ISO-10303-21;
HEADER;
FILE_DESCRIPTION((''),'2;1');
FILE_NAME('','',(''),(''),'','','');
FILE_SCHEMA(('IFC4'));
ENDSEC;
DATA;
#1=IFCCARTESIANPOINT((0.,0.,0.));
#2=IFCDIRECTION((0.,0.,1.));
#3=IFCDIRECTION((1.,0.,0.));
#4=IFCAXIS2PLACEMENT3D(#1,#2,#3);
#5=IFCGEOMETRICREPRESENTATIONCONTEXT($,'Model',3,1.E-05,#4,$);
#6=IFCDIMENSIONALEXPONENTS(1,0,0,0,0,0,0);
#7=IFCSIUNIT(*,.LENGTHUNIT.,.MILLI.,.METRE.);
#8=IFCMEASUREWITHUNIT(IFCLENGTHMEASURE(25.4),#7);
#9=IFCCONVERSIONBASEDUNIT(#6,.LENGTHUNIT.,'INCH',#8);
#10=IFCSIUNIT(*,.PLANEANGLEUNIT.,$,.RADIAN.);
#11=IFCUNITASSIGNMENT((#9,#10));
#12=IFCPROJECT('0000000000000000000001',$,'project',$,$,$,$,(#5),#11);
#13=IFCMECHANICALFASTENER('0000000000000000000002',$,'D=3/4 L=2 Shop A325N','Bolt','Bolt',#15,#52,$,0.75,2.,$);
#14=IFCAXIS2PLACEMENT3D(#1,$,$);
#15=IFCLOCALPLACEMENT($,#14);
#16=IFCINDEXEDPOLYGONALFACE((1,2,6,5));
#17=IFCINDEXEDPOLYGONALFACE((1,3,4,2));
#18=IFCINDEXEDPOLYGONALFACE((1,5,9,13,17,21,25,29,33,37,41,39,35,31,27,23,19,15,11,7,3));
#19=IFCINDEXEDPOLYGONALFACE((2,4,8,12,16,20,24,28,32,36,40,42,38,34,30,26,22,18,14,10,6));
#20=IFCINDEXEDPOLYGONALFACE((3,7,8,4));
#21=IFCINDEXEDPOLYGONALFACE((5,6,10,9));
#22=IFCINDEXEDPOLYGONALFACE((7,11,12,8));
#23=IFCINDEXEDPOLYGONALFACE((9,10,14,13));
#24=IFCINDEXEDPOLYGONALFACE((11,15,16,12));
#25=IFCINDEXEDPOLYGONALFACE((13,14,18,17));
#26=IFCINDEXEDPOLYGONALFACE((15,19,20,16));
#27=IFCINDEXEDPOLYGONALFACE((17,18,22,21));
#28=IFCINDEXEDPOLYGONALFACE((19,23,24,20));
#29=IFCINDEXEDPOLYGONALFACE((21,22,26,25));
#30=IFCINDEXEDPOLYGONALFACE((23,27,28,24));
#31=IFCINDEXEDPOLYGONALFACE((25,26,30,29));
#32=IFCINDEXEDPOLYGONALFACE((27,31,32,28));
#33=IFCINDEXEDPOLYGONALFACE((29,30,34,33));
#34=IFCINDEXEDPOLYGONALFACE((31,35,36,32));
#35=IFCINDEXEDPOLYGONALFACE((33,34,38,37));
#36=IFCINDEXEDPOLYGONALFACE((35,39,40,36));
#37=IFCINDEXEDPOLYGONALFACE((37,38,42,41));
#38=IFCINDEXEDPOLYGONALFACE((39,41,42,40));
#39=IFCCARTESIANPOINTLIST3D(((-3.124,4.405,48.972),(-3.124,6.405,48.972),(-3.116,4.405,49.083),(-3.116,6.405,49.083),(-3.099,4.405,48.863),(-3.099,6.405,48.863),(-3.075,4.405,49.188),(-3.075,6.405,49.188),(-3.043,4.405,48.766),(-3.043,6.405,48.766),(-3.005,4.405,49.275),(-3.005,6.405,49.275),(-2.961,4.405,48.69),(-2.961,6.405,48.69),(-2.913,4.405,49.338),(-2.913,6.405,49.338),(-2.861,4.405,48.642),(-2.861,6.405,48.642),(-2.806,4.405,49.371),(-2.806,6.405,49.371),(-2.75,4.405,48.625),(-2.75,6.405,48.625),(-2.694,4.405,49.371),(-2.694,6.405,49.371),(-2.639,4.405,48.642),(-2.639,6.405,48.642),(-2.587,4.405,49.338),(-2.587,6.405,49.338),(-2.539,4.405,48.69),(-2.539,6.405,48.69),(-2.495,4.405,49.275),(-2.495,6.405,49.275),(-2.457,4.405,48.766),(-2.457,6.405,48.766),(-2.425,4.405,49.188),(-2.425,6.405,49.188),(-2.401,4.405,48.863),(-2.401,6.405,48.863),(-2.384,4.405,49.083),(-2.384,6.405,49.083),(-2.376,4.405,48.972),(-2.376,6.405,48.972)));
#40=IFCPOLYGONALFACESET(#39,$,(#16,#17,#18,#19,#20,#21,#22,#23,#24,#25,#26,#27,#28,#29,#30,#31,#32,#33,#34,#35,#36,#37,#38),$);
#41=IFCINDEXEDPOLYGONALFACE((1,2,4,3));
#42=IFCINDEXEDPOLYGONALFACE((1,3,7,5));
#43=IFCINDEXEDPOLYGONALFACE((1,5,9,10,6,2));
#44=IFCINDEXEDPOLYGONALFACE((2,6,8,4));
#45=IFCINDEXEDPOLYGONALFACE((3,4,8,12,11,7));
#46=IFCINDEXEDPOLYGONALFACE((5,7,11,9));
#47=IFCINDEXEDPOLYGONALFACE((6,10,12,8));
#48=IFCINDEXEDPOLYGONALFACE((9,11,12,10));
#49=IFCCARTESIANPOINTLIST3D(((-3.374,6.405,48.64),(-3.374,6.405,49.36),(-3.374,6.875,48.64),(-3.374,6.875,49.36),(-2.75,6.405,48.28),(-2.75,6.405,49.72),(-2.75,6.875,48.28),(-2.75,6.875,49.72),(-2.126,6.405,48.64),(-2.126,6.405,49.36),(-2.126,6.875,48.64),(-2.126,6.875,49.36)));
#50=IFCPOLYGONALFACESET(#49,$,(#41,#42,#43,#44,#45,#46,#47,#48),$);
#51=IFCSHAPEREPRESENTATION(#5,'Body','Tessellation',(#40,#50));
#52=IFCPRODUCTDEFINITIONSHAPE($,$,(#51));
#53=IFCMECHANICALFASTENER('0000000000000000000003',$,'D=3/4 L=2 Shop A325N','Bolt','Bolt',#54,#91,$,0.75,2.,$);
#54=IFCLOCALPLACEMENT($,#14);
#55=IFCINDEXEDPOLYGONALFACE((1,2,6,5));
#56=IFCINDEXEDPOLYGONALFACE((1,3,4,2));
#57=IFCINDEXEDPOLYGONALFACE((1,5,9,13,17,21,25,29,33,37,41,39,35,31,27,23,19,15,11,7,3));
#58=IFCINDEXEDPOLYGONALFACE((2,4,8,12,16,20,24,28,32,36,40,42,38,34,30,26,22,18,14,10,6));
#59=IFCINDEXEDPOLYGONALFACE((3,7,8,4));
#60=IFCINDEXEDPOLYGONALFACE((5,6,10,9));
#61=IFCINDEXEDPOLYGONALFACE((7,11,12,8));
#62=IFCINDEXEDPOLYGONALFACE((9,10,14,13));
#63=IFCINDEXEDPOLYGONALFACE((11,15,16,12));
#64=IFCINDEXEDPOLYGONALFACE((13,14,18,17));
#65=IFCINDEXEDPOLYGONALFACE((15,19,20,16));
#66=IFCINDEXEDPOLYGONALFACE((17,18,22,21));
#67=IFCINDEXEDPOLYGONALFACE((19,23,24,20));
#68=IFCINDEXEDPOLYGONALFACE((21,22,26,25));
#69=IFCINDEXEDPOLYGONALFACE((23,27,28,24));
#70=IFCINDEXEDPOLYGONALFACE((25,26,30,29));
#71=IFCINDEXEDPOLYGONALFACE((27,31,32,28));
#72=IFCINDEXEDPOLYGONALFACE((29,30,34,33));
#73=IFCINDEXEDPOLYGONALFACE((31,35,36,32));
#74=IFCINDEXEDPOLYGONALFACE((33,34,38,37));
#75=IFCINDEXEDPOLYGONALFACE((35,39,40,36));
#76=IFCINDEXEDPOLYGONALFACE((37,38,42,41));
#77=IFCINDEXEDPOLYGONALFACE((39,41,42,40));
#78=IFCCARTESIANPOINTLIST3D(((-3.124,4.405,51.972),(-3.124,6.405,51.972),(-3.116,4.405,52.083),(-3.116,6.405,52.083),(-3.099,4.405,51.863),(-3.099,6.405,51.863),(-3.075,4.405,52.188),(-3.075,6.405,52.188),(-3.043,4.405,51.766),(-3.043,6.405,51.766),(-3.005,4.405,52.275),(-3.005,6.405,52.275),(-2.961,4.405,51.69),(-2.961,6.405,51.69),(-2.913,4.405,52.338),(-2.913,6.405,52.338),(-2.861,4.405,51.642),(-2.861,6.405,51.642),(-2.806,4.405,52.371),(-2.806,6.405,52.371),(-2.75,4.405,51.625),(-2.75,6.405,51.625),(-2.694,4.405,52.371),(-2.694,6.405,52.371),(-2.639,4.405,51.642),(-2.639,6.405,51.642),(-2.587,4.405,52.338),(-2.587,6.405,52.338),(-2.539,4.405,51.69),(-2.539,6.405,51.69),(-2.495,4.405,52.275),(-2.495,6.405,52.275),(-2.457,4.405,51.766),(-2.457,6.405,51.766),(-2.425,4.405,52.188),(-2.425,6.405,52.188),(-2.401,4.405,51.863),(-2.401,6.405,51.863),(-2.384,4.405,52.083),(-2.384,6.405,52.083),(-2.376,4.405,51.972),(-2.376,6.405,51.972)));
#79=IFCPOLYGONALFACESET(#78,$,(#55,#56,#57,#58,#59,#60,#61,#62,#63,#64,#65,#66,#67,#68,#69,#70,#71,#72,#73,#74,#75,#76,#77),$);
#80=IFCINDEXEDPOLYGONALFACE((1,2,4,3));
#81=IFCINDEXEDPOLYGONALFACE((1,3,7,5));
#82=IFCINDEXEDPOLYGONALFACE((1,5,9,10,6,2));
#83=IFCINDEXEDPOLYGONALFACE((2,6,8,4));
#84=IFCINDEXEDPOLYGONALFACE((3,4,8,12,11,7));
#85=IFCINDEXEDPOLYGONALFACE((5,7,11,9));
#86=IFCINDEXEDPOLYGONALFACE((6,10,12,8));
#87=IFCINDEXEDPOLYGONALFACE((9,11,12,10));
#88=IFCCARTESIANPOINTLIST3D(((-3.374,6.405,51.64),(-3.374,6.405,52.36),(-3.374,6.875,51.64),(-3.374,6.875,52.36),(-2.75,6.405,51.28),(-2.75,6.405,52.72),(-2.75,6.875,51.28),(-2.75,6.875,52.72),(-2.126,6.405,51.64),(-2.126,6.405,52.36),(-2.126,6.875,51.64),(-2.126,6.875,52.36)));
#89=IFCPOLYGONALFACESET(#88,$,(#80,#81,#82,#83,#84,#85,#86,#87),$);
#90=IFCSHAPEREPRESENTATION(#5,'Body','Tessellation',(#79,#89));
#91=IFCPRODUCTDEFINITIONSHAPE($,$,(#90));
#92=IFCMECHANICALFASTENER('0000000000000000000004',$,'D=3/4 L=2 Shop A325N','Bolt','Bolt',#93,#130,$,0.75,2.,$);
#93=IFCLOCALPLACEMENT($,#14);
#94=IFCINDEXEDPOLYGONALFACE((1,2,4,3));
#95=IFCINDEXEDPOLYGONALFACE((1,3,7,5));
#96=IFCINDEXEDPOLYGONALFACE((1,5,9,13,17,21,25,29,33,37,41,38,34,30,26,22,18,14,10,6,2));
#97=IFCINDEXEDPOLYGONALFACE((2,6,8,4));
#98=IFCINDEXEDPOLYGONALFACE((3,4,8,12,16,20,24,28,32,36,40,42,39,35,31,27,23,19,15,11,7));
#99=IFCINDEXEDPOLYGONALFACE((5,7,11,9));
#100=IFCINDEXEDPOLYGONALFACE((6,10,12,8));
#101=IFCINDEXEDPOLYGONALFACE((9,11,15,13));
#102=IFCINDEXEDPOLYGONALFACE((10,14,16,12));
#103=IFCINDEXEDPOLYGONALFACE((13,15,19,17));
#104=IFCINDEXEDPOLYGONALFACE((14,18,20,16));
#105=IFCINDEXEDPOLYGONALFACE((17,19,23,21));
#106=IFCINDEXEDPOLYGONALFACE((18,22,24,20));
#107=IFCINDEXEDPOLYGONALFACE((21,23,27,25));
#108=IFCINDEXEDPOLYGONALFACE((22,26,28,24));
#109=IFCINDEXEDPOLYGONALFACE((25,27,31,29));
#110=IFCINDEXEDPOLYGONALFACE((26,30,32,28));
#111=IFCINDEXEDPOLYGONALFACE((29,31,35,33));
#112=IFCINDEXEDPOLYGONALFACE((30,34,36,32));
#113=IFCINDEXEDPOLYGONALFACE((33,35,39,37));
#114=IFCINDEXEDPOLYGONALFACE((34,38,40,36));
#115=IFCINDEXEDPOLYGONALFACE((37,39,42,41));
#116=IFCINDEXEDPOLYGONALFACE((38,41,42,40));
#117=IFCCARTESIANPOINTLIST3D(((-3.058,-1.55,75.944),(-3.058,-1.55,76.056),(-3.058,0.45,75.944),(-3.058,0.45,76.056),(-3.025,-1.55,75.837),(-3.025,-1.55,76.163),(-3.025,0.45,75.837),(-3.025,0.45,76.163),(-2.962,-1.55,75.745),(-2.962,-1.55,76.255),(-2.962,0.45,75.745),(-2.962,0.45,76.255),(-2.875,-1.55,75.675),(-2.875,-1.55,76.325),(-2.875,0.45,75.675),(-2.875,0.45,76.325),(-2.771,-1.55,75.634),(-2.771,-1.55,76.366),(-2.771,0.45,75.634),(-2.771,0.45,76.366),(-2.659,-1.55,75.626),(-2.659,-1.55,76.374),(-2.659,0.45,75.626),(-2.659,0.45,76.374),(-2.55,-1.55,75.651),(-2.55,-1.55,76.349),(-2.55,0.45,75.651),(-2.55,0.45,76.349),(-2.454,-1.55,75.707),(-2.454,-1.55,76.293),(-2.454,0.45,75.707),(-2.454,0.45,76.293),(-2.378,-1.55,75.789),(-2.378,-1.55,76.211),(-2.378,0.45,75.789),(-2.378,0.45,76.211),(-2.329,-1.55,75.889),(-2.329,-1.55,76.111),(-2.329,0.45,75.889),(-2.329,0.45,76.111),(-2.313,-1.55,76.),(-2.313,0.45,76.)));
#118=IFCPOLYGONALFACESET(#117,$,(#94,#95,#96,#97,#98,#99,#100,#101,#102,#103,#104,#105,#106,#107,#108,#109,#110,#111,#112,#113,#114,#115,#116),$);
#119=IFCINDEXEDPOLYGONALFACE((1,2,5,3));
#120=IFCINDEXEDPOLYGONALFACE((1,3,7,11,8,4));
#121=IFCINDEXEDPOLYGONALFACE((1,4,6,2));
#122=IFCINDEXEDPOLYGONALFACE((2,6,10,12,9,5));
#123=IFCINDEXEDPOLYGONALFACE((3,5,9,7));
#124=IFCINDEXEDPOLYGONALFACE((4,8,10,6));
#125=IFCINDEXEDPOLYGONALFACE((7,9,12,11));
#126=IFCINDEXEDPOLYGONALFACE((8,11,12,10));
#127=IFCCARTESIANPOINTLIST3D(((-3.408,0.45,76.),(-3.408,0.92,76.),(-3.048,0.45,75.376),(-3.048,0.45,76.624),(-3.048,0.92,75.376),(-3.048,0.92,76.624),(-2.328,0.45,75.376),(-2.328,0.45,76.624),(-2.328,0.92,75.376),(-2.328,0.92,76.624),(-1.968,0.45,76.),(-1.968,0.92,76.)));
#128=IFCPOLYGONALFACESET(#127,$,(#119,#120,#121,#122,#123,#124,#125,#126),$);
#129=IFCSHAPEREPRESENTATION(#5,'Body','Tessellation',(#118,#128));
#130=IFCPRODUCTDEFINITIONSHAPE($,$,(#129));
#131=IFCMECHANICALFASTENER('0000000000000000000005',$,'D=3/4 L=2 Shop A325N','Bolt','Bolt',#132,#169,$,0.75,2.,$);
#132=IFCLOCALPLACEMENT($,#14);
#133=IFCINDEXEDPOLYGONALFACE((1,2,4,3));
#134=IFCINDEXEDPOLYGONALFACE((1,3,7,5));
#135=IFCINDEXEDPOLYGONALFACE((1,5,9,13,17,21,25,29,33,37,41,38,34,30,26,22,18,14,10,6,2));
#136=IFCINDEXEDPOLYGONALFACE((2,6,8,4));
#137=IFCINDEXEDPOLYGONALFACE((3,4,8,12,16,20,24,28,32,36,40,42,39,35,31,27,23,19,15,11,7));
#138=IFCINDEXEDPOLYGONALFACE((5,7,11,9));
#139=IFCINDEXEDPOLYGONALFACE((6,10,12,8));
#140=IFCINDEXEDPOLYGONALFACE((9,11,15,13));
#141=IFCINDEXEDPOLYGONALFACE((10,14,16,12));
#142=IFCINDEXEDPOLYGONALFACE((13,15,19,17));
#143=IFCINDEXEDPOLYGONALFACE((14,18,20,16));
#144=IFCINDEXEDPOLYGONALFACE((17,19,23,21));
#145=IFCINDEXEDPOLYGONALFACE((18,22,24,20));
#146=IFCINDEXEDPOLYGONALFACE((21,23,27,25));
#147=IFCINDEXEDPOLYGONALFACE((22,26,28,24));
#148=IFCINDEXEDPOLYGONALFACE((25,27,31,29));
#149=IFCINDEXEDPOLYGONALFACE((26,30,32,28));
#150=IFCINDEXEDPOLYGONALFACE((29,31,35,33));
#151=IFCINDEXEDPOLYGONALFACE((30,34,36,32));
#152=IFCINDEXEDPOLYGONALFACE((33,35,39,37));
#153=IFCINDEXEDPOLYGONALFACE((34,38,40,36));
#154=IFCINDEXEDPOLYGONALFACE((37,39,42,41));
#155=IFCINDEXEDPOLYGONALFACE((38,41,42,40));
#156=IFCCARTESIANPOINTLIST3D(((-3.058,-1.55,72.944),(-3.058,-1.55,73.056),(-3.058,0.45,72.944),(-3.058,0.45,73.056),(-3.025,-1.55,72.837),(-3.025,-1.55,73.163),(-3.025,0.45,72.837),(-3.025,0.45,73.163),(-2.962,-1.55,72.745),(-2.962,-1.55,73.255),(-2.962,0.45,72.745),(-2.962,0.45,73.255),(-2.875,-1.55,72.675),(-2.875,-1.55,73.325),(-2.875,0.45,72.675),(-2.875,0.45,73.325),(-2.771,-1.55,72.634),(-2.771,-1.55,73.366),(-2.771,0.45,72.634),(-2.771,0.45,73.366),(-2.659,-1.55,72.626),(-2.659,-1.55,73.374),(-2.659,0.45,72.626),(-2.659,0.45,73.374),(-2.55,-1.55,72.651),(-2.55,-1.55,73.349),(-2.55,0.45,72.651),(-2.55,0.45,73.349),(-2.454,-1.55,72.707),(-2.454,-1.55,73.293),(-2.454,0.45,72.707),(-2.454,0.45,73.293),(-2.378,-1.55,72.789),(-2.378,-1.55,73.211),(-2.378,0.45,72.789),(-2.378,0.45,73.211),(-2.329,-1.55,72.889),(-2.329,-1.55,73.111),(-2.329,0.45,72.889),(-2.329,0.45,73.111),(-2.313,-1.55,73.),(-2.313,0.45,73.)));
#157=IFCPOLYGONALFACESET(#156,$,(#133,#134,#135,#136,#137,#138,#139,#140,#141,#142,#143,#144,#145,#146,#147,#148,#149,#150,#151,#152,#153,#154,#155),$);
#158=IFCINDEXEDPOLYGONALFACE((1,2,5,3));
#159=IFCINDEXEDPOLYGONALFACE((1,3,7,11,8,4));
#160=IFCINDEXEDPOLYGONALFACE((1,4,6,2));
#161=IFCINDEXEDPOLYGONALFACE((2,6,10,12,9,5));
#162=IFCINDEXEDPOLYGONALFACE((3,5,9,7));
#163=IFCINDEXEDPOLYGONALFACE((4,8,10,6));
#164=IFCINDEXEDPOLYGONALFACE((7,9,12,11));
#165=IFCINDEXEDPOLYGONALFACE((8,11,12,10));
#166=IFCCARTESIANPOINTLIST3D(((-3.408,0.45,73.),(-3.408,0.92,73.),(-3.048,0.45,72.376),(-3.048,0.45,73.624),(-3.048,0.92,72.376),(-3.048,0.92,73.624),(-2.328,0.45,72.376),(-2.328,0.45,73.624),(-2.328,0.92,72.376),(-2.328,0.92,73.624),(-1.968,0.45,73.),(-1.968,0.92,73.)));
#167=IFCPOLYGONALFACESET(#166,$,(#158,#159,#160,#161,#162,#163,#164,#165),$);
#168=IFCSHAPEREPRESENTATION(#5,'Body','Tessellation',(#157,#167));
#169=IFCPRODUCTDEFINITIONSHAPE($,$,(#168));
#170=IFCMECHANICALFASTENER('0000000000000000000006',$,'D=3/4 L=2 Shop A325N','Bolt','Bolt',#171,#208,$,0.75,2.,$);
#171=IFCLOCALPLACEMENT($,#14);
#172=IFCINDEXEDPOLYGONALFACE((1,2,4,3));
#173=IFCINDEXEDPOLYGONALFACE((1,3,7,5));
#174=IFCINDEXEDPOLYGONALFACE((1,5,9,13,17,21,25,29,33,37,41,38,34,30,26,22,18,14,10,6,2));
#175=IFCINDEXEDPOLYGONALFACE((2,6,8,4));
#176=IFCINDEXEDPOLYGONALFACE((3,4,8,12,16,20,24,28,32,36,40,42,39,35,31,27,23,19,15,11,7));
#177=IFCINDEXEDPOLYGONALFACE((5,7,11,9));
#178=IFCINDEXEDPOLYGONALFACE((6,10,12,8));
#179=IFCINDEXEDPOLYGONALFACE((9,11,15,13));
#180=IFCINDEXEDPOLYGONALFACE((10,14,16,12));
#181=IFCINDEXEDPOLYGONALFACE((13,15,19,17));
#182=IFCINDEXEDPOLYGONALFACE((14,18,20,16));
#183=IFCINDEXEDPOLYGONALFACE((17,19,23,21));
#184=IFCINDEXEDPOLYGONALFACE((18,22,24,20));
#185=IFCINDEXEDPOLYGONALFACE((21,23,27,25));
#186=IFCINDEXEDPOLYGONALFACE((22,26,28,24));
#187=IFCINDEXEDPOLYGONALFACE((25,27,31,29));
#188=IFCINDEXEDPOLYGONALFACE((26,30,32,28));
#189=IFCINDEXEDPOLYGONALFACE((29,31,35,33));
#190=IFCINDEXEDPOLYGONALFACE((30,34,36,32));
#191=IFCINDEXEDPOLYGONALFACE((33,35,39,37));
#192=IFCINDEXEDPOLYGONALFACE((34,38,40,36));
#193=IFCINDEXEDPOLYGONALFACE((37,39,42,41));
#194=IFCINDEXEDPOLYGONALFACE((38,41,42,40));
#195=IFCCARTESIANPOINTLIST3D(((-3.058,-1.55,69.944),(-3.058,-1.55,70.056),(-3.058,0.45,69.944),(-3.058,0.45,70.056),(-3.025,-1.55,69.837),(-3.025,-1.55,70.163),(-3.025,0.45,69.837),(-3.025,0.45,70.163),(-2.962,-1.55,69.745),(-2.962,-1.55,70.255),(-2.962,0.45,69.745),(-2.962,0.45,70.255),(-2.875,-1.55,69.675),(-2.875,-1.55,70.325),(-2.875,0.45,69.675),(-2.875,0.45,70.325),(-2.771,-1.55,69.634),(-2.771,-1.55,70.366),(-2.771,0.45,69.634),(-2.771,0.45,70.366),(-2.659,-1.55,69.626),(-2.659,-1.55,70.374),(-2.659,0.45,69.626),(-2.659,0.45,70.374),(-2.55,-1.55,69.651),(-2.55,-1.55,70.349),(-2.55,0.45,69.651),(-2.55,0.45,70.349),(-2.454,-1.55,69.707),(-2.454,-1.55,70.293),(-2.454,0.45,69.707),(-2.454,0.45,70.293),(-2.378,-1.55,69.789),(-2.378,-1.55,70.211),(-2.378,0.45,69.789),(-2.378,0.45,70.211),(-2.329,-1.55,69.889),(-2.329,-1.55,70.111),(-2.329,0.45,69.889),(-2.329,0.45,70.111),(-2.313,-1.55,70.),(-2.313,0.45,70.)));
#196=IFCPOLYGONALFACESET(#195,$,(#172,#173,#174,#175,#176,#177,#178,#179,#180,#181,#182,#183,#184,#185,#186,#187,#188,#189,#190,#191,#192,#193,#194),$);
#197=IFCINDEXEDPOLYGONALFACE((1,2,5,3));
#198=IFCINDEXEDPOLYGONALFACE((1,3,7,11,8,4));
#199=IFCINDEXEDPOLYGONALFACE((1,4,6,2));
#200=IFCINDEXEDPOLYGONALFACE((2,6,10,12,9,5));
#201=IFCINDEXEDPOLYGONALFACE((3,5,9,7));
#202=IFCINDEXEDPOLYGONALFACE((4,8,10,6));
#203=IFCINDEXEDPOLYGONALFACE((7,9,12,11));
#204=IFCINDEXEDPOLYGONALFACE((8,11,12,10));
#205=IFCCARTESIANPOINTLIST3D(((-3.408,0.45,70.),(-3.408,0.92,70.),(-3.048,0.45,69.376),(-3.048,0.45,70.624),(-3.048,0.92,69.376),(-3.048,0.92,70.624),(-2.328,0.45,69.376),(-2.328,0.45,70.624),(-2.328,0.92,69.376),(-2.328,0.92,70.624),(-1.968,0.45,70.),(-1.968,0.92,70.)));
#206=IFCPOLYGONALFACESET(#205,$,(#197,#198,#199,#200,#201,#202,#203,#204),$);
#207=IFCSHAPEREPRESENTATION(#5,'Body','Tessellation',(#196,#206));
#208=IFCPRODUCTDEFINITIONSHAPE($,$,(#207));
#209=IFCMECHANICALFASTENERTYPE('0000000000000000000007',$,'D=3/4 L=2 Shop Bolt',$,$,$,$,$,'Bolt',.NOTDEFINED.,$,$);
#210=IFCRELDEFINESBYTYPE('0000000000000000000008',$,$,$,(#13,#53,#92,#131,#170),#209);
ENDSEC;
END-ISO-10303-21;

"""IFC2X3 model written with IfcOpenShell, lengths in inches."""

from ifc_helpers import new_model, entity, si_unit, converted_unit, frame, origin_with_axes, origin_2d_with_axis, place, context, project, polyline, circle, outline, extrude, source, transform, mapped, type_object, type_shapes, element, save


model = new_model("IFC2X3")

# Units and contexts
model_context = context("Model", 3, precision=1e-05, world=origin_with_axes())
ifc_project = project(units=[converted_unit("LENGTHUNIT", "INCH", entity("IfcLengthMeasure", 25.4), si_unit("LENGTHUNIT", "METRE", prefix="MILLI"), dimensions=[1, 0, 0, 0, 0, 0, 0]), si_unit("PLANEANGLEUNIT", "RADIAN")], contexts=[model_context])

# Mechanical fasteners
placement_1 = place(None, origin_with_axes())
placement_2 = place(placement_1, origin_with_axes())
mechanical_fastener_type_1 = type_object("IfcMechanicalFastenerType", Name="D=3/4 L=2 Shop Bolt", ElementType="Bolt")
shared_shape_1 = source(origin_with_axes(), model_context, "Body", "SweptSolid", [
    extrude(circle(Radius=0.375, at=origin_2d_with_axis()), frame((0.0, 0.0, 0.0), z_axis=(1.0, 0.0, 0.0), x_axis=(0.0, 1.0, 0.0)), (0.0, 0.0, 1.0), 2.0),
    extrude(outline(polyline([(-0.72, 0.0), (-0.36, 0.624), (0.36, 0.624), (0.72, 0.0), (0.36, -0.624), (-0.36, -0.624), (-0.72, 0.0)])), frame((0.0, 0.0, 0.0), z_axis=(1.0, 0.0, 0.0), x_axis=(0.0, 1.0, 0.0)), (0.0, 0.0, -1.0), 0.47),
])
type_shapes(mechanical_fastener_type_1, [shared_shape_1])
placement_3 = place(placement_2, frame((0.0, 0.0, 21.0), z_axis=(0.0, -1.0, 0.0), x_axis=(0.0, 0.0, 1.0)))
placement_4 = place(placement_3, frame((31.0, 2.75, -6.405), z_axis=(0.0, -1.0, 0.0), x_axis=(0.0, 0.0, 1.0)))
for number, where, z_axis, x_axis, name in (
    (1, (0.0, 3.0, 0.0), (0.0, 0.0, 1.0), (1.0, 0.0, 0.0), "D=3/4 L=2 Shop A325N"),
    (2, (0.0, 0.0, 0.0), (0.0, 0.0, 1.0), (1.0, 0.0, 0.0), "D=3/4 L=2 Shop A325N"),
):
    element("IfcMechanicalFastener", number, at=place(placement_4, frame(where, z_axis=z_axis, x_axis=x_axis)), type_object=mechanical_fastener_type_1, Name=name, Description="Bolt", ObjectType="Bolt", NominalDiameter=0.75, NominalLength=2.0, context=model_context, shape_type="MappedRepresentation", body=[
        mapped(shared_shape_1, transform((0.0, 0.0, 0.0), scale=1.0)),
    ])
placement_5 = place(placement_2, frame((0.0, 0.0, 80.0), z_axis=(0.0, 0.0, 1.0), x_axis=(-1.0, 0.0, 0.0)))
placement_6 = place(placement_5, frame((2.688, -0.45, -10.0), z_axis=(0.0, 0.0, 1.0), x_axis=(0.0, 1.0, 0.0)))
for number, where, z_axis, x_axis, name in (
    (3, (0.0, 0.0, 6.0), (0.0, 0.0, 1.0), (1.0, 0.0, 0.0), "D=3/4 L=2 Shop A325N"),
    (4, (0.0, 0.0, 3.0), (0.0, 0.0, 1.0), (1.0, 0.0, 0.0), "D=3/4 L=2 Shop A325N"),
    (5, (0.0, 0.0, 0.0), (0.0, 0.0, 1.0), (1.0, 0.0, 0.0), "D=3/4 L=2 Shop A325N"),
):
    element("IfcMechanicalFastener", number, at=place(placement_6, frame(where, z_axis=z_axis, x_axis=x_axis)), type_object=mechanical_fastener_type_1, Name=name, Description="Bolt", ObjectType="Bolt", NominalDiameter=0.75, NominalLength=2.0, context=model_context, shape_type="MappedRepresentation", body=[
        mapped(shared_shape_1, transform((0.0, 0.0, 0.0), scale=1.0)),
    ])

save(model, "model.ifc")
